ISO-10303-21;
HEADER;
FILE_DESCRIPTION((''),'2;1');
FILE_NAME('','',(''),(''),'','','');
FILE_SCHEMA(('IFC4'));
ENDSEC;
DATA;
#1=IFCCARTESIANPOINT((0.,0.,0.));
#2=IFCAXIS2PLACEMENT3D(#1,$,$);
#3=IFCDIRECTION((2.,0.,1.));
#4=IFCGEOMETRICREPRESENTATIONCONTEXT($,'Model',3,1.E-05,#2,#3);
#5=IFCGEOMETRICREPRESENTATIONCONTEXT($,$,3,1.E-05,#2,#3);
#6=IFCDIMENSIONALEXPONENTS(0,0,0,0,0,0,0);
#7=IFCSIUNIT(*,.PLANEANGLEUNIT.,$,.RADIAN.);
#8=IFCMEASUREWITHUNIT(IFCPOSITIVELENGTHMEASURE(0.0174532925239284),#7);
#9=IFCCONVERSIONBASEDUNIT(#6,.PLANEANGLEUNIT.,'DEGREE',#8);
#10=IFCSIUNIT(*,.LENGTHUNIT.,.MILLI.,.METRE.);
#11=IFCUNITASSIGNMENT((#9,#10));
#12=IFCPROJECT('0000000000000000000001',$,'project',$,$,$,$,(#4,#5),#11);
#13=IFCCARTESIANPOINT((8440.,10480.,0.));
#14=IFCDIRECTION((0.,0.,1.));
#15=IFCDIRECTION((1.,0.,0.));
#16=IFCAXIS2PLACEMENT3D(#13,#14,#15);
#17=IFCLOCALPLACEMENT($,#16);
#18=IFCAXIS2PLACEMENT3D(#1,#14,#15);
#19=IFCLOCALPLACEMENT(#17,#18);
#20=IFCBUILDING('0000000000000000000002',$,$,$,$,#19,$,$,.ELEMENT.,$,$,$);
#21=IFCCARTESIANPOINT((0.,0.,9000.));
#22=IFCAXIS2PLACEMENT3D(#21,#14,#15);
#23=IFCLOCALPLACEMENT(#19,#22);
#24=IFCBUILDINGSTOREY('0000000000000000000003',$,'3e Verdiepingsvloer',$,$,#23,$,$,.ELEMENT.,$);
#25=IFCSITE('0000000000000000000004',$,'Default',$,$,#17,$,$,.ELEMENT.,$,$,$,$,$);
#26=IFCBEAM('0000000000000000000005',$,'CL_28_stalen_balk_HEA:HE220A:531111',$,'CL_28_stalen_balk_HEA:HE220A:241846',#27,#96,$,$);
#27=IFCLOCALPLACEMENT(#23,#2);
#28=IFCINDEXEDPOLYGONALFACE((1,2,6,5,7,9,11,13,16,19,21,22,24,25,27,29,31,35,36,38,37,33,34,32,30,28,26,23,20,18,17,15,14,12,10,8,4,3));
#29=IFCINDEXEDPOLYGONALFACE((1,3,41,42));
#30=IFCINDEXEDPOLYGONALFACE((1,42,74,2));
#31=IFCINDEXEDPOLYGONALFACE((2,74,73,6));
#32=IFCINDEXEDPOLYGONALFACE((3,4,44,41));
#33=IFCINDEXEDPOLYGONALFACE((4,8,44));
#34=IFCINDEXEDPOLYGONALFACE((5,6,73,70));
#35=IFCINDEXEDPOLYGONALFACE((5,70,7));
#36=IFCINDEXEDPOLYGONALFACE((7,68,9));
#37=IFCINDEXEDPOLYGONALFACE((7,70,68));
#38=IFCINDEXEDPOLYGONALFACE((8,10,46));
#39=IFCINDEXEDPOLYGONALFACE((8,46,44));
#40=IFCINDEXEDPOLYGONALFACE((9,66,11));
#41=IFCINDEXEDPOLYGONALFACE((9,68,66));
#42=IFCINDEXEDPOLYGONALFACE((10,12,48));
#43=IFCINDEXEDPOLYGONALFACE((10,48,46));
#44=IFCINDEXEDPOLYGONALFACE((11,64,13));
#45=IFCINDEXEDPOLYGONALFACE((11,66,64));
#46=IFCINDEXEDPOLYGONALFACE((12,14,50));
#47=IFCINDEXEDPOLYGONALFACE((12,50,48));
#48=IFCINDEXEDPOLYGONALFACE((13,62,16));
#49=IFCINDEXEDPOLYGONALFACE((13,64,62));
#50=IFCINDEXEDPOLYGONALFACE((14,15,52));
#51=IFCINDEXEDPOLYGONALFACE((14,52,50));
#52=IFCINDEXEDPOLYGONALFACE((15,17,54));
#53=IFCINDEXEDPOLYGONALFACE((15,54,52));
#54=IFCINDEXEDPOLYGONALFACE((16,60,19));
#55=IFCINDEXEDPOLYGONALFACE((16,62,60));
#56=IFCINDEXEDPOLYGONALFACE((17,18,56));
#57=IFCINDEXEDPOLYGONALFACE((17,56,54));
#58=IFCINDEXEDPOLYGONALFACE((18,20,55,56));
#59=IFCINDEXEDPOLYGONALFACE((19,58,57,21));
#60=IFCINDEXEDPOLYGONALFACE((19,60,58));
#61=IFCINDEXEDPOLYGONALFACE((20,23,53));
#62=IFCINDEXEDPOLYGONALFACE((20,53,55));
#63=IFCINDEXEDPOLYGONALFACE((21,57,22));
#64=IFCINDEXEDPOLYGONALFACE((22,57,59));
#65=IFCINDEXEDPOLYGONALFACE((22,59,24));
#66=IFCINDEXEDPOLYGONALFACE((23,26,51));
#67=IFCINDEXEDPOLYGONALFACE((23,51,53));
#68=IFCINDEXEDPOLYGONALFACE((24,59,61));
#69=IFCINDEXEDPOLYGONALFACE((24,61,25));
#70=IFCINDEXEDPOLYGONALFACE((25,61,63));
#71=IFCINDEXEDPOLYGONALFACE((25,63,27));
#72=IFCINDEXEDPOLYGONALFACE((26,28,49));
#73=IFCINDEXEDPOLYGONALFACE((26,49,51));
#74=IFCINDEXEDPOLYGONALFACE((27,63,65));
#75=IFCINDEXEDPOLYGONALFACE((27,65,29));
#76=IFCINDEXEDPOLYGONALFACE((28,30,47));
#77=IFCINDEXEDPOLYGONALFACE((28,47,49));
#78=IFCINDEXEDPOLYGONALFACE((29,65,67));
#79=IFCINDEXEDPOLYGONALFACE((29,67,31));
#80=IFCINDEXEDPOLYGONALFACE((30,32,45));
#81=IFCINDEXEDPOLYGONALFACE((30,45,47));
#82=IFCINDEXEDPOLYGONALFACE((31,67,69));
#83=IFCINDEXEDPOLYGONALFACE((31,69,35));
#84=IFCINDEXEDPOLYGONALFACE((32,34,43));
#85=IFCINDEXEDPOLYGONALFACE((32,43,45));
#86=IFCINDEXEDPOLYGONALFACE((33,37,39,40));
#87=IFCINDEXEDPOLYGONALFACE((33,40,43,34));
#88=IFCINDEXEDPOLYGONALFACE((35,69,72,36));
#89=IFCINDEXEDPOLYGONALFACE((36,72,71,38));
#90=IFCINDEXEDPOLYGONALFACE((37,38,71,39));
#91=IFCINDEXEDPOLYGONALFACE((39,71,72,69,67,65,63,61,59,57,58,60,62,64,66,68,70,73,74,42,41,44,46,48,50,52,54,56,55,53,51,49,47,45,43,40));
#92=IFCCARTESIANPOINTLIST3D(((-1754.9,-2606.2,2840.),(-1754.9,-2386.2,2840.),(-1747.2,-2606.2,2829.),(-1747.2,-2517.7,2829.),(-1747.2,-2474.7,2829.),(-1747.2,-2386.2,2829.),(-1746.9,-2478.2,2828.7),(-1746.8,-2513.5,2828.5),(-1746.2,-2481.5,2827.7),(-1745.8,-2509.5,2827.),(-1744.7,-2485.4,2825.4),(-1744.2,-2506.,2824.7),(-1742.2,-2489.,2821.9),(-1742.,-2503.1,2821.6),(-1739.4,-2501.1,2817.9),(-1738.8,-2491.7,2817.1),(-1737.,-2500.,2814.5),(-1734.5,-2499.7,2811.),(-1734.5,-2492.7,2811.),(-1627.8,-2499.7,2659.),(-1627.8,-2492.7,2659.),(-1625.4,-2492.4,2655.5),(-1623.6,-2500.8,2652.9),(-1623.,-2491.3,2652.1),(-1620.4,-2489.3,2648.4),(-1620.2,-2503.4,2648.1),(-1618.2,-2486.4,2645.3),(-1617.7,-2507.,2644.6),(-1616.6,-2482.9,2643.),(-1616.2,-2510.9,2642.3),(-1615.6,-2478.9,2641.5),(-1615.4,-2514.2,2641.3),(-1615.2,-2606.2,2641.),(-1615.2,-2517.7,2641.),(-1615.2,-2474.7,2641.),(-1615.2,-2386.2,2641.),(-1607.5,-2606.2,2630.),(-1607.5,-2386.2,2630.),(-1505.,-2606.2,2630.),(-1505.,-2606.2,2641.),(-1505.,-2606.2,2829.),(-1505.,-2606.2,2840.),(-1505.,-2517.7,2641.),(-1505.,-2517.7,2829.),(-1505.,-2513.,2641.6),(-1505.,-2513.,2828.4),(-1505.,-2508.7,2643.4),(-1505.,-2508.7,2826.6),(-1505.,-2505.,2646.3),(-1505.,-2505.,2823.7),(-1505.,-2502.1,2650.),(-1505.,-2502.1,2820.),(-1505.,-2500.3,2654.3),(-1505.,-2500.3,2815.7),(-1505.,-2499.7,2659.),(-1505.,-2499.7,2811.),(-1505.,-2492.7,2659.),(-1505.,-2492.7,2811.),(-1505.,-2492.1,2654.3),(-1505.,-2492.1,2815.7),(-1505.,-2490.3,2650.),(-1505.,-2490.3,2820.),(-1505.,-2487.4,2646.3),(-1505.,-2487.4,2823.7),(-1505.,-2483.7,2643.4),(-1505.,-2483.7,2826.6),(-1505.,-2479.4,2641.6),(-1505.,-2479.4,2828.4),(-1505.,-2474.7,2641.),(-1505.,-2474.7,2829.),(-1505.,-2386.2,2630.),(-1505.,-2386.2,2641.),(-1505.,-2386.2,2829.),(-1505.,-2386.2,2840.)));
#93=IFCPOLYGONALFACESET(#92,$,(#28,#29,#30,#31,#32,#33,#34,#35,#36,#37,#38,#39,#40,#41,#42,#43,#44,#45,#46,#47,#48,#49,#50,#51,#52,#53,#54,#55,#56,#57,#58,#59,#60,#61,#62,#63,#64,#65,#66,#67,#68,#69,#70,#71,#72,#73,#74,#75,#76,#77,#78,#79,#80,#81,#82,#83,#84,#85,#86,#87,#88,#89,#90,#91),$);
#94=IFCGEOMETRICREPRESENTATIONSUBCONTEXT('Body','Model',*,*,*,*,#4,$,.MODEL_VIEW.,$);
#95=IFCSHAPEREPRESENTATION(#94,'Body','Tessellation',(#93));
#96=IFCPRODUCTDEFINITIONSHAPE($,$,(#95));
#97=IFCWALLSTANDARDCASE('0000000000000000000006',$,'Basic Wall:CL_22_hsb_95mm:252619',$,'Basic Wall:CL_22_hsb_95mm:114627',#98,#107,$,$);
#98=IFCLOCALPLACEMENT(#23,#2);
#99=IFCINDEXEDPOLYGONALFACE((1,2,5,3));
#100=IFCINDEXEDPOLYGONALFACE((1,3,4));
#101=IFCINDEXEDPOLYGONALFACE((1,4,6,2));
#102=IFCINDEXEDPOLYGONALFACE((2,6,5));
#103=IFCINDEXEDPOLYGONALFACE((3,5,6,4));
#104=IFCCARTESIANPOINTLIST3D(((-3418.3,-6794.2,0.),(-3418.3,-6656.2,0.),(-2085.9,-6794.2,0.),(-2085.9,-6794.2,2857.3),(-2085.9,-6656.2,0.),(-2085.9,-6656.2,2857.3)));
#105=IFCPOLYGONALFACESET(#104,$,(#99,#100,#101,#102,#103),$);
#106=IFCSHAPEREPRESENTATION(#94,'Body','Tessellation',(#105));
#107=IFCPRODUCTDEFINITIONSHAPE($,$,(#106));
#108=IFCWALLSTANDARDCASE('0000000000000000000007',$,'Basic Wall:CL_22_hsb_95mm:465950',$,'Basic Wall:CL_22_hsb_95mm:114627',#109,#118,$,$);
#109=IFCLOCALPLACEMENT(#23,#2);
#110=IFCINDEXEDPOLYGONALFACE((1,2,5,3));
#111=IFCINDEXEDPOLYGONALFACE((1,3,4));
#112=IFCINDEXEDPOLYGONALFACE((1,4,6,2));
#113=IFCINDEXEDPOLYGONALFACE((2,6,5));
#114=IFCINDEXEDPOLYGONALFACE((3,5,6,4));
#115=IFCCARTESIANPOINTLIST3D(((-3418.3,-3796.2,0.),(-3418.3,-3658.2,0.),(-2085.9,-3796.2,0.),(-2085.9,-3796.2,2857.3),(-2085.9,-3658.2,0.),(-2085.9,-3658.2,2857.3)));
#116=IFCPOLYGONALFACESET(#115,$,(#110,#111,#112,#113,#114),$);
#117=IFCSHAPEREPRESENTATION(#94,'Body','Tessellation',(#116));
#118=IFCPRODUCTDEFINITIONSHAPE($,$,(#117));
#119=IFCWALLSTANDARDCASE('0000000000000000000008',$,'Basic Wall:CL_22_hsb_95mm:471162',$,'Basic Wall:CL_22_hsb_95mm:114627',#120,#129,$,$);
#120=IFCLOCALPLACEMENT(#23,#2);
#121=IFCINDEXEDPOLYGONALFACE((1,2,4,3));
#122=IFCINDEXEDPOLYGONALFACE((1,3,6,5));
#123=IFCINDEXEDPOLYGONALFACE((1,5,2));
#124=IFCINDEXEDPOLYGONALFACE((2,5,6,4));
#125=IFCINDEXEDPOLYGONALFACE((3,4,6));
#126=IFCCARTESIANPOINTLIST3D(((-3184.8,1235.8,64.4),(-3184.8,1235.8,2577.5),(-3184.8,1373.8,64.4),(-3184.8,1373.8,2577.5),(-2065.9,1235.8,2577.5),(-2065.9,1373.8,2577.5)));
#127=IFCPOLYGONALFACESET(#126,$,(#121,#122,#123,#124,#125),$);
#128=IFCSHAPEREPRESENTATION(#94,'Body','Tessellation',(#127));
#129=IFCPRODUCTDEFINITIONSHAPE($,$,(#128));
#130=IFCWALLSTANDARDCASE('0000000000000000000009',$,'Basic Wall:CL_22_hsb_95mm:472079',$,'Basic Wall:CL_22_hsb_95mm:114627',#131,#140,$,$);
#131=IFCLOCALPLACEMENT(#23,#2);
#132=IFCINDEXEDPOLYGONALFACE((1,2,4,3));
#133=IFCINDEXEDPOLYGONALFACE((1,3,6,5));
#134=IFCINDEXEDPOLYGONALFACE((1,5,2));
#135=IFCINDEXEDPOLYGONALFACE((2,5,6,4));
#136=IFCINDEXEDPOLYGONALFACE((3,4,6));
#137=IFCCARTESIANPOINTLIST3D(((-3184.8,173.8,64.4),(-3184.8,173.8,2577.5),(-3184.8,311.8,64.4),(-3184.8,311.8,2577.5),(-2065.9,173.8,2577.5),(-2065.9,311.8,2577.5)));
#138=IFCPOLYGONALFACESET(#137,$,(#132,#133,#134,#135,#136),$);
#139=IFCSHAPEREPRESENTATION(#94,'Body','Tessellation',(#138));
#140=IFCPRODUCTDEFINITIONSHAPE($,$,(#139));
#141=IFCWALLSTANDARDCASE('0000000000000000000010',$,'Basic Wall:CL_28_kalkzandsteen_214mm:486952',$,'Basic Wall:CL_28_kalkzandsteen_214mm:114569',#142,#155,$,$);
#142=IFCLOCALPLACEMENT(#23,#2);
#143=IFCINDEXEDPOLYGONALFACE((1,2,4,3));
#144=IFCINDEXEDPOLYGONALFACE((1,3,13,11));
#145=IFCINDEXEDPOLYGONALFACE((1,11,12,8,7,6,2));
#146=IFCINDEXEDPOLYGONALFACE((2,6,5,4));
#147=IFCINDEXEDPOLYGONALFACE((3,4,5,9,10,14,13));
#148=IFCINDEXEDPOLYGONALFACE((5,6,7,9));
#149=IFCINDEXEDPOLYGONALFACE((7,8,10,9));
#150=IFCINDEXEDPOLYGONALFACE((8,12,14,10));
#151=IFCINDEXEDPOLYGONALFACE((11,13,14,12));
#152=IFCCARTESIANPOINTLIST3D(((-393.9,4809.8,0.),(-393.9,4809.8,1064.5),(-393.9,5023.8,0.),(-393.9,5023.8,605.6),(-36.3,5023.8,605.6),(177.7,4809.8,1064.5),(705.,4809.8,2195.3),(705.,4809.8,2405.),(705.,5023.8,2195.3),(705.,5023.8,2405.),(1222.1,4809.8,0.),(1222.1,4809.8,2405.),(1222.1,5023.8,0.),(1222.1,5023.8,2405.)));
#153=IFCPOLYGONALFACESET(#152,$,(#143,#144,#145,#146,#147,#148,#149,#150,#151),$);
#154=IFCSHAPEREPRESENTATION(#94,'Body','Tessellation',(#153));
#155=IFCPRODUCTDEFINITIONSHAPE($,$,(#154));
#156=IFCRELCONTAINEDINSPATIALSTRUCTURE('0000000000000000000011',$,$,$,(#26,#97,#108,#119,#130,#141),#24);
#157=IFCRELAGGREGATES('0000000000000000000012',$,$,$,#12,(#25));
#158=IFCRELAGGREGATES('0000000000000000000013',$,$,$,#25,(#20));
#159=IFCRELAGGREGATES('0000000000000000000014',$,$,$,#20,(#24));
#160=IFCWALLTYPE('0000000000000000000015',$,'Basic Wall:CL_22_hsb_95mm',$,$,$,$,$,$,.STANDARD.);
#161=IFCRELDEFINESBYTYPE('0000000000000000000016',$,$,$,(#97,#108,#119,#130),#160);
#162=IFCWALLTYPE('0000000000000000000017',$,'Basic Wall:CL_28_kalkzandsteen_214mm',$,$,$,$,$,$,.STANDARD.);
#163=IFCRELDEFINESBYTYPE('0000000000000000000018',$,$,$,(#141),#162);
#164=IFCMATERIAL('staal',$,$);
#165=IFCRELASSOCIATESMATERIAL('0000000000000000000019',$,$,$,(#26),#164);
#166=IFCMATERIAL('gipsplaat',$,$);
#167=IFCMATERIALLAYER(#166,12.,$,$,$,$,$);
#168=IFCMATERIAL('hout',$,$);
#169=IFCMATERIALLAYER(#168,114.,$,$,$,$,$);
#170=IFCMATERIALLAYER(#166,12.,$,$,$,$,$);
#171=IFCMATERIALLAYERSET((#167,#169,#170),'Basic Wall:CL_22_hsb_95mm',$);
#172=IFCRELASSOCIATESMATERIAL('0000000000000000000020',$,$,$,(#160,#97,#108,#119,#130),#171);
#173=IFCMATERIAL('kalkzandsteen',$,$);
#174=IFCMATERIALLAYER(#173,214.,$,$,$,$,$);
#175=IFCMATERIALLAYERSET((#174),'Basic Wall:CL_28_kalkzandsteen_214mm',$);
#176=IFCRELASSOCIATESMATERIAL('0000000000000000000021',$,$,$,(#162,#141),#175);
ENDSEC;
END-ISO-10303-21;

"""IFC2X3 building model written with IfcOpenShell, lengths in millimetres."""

from ifc_helpers import new_model, entity, si_unit, converted_unit, direction, frame, frame_2d, origin, origin_with_axes, place, context, subcontext, project, spatial, polyline, rectangle, i_section, extrude, clip, halfspace, bounded_halfspace, source, transform, mapped, material, layer, layer_set, layer_usage, type_object, element, save


model = new_model("IFC2X3")

# Units and contexts
model_context = context("Model", 3, precision=1e-05, world=origin(), true_north=direction((2.0, 0.0, 1.0)))
context_of_model = context(None, 3, precision=1e-05, world=origin(), true_north=direction((2.0, 0.0, 1.0)))
body_context = subcontext(model_context, "Body", "Model", "MODEL_VIEW")
ifc_project = project(units=[converted_unit("PLANEANGLEUNIT", "DEGREE", entity("IfcPositiveLengthMeasure", 0.0174532925239284), si_unit("PLANEANGLEUNIT", "RADIAN"), dimensions=[0, 0, 0, 0, 0, 0, 0]), si_unit("LENGTHUNIT", "METRE", prefix="MILLI")], contexts=[model_context, context_of_model])

# Site, building, storey
site_placement = place(None, frame((8440.0, 10480.0, 0.0), z_axis=(0.0, 0.0, 1.0), x_axis=(1.0, 0.0, 0.0)))
site = spatial("IfcSite", under=ifc_project, at=site_placement, Name="Default", CompositionType="ELEMENT")
building_placement = place(site_placement, origin_with_axes())
building = spatial("IfcBuilding", under=site, at=building_placement, CompositionType="ELEMENT")
storey_placement = place(building_placement, frame((0.0, 0.0, 9000.0), z_axis=(0.0, 0.0, 1.0), x_axis=(1.0, 0.0, 0.0)))
storey = spatial("IfcBuildingStorey", under=building, at=storey_placement, Name="3e Verdiepingsvloer", CompositionType="ELEMENT")

# Beam
ifc_material_1 = material(Name="staal")
ifc_material_2 = material(Name="hout")
beam_1_placement = place(storey_placement, frame((-2063.1, -2496.2, 2840.0), z_axis=(0.0, 0.0, 1.0), x_axis=(1.0, 0.0, 0.0)))
element("IfcBeam", 1, at=beam_1_placement, inside=storey, material=ifc_material_1, Name="CL_28_stalen_balk_HEA:HE220A:531111", ObjectType="CL_28_stalen_balk_HEA:HE220A:241846", context=body_context, shape_type="Clipping", body=[
    clip(extrude(i_section(OverallWidth=220.0, OverallDepth=210.0, WebThickness=7.0, FlangeThickness=11.0, FilletRadius=18.0, at=frame_2d((0.0, 0.0), x_axis=(0.0, 1.0))), frame((308.2, 0.0, -105.0), z_axis=(1.0, 0.0, 0.0), x_axis=(0.0, 0.0, -1.0)), (0.0, 0.0, 1.0), 249.9), halfspace(frame((300.1, -5856.2, 11.6), z_axis=(-0.818469, 0.0, -0.574551), x_axis=(0.574551, 0.0, -0.818469)), False)),
])

# Walls
ifc_material_3 = material(Name="gipsplaat")
ifc_layer_1 = layer(ifc_material_3, 12.0)
ifc_layer_2 = layer(ifc_material_2, 114.0)
ifc_layer_3 = layer(ifc_material_3, 12.0)
ifc_layer_set_1 = layer_set([ifc_layer_1, ifc_layer_2, ifc_layer_3], Name="Basic Wall:CL_22_hsb_95mm")
ifc_layer_usage_1 = layer_usage(ifc_layer_set_1, "AXIS2", "NEGATIVE", 69.0)
wall_type_1 = type_object("IfcWallType", Name="Basic Wall:CL_22_hsb_95mm", PredefinedType="STANDARD", material=ifc_layer_set_1)
shared_shape_1 = source(origin(), body_context, "Body", "Clipping", [
    clip(extrude(rectangle(XDim=1332.4, YDim=138.0, at=frame_2d((666.2, 0.0), x_axis=(-1.0, 0.0))), origin(), (0.0, 0.0, 1.0), 2860.0), halfspace(frame((0.0, -69.0, 2857.3), z_axis=(0.906308, 0.0, 0.422618), x_axis=(0.0, 1.0, 0.0)), False)),
])
wall_1_placement = place(storey_placement, frame((-2085.9, -6725.2, 0.0), z_axis=(0.0, 0.0, 1.0), x_axis=(-1.0, 0.0, 0.0)))
element("IfcWallStandardCase", 2, at=wall_1_placement, inside=storey, type_object=wall_type_1, material=ifc_layer_usage_1, Name="Basic Wall:CL_22_hsb_95mm:252619", ObjectType="Basic Wall:CL_22_hsb_95mm:114627", context=body_context, shape_type="MappedRepresentation", body=[
    mapped(shared_shape_1, transform((0.0, 0.0, 0.0))),
])
ifc_layer_usage_2 = layer_usage(ifc_layer_set_1, "AXIS2", "POSITIVE", -69.0)
wall_2_placement = place(storey_placement, frame((-2085.9, -3727.2, 0.0), z_axis=(0.0, 0.0, 1.0), x_axis=(-1.0, 0.0, 0.0)))
element("IfcWallStandardCase", 3, at=wall_2_placement, inside=storey, type_object=wall_type_1, material=ifc_layer_usage_2, Name="Basic Wall:CL_22_hsb_95mm:465950", ObjectType="Basic Wall:CL_22_hsb_95mm:114627", context=body_context, shape_type="MappedRepresentation", body=[
    mapped(shared_shape_1, transform((0.0, 0.0, 0.0))),
])
ifc_layer_usage_3 = layer_usage(ifc_layer_set_1, "AXIS2", "POSITIVE", -69.0)
shared_shape_2 = source(origin(), body_context, "Body", "Clipping", [
    clip(clip(extrude(rectangle(XDim=1118.9, YDim=138.0, at=frame_2d((559.5, 0.0), x_axis=(-1.0, 0.0))), origin(), (0.0, 0.0, 1.0), 2860.0), halfspace(frame((1118.9, -69.0, 64.4), z_axis=(-0.913545, 0.0, -0.406737), x_axis=(0.0, 1.0, 0.0)), False)), halfspace(frame((0.0, -69.0, 2577.5), z_axis=(0.0, 0.0, 1.0), x_axis=(0.0, 1.0, 0.0)), False)),
])
wall_3_placement = place(storey_placement, frame((-2065.9, 1304.8, 0.0), z_axis=(0.0, 0.0, 1.0), x_axis=(-1.0, 0.0, 0.0)))
element("IfcWallStandardCase", 4, at=wall_3_placement, inside=storey, type_object=wall_type_1, material=ifc_layer_usage_3, Name="Basic Wall:CL_22_hsb_95mm:471162", ObjectType="Basic Wall:CL_22_hsb_95mm:114627", context=body_context, shape_type="MappedRepresentation", body=[
    mapped(shared_shape_2, transform((0.0, 0.0, 0.0))),
])
ifc_layer_usage_4 = layer_usage(ifc_layer_set_1, "AXIS2", "POSITIVE", -69.0)
wall_4_placement = place(storey_placement, frame((-2065.9, 242.8, 0.0), z_axis=(0.0, 0.0, 1.0), x_axis=(-1.0, 0.0, 0.0)))
element("IfcWallStandardCase", 5, at=wall_4_placement, inside=storey, type_object=wall_type_1, material=ifc_layer_usage_4, Name="Basic Wall:CL_22_hsb_95mm:472079", ObjectType="Basic Wall:CL_22_hsb_95mm:114627", context=body_context, shape_type="MappedRepresentation", body=[
    mapped(shared_shape_2, transform((0.0, 0.0, 0.0))),
])
ifc_material_4 = material(Name="kalkzandsteen")
ifc_layer_4 = layer(ifc_material_4, 214.0)
ifc_layer_set_2 = layer_set([ifc_layer_4], Name="Basic Wall:CL_28_kalkzandsteen_214mm")
wall_type_2 = type_object("IfcWallType", Name="Basic Wall:CL_28_kalkzandsteen_214mm", PredefinedType="STANDARD", material=ifc_layer_set_2)
ifc_layer_usage_5 = layer_usage(ifc_layer_set_2, "AXIS2", "NEGATIVE", 107.0)
wall_5_placement = place(storey_placement, frame((1222.1, 4916.8, 0.0), z_axis=(0.0, 0.0, 1.0), x_axis=(-1.0, 0.0, 0.0)))
element("IfcWallStandardCase", 6, at=wall_5_placement, inside=storey, type_object=wall_type_2, material=ifc_layer_usage_5, Name="Basic Wall:CL_28_kalkzandsteen_214mm:486952", ObjectType="Basic Wall:CL_28_kalkzandsteen_214mm:114569", context=body_context, shape_type="Clipping", body=[
    clip(clip(clip(extrude(rectangle(XDim=1616.0, YDim=214.0, at=frame_2d((808.0, 0.0), x_axis=(-1.0, 0.0))), origin(), (0.0, 0.0, 1.0), 2640.0), bounded_halfspace(frame((0.0, -107.0, 2405.0), z_axis=(0.0, 0.0, 1.0), x_axis=(-1.0, 0.0, 0.0)), False, frame((0.0, -107.0, 2405.0)), polyline([(0.0, 0.0), (517.1, 0.0), (517.1, 214.0), (0.0, 214.0), (0.0, 0.0)]))), bounded_halfspace(frame((1258.4, -107.0, 605.6), z_axis=(0.0, -0.906308, 0.422618), x_axis=(1.0, 0.0, 0.0)), False, frame((1258.4, -107.0, 605.6)), polyline([(0.0, 0.0), (357.6, 0.0), (357.6, 214.0), (-214.0, 214.0), (0.0, 0.0)]))), bounded_halfspace(frame((517.1, -107.0, 2195.3), z_axis=(0.906308, 0.0, 0.422618), x_axis=(0.0, 1.0, 0.0)), False, frame((517.1, -107.0, 2195.3)), polyline([(0.0, 0.0), (741.3, 0.0), (527.3, 214.0), (0.0, 214.0), (0.0, 0.0)]))),
])

save(model, "model.ifc")
